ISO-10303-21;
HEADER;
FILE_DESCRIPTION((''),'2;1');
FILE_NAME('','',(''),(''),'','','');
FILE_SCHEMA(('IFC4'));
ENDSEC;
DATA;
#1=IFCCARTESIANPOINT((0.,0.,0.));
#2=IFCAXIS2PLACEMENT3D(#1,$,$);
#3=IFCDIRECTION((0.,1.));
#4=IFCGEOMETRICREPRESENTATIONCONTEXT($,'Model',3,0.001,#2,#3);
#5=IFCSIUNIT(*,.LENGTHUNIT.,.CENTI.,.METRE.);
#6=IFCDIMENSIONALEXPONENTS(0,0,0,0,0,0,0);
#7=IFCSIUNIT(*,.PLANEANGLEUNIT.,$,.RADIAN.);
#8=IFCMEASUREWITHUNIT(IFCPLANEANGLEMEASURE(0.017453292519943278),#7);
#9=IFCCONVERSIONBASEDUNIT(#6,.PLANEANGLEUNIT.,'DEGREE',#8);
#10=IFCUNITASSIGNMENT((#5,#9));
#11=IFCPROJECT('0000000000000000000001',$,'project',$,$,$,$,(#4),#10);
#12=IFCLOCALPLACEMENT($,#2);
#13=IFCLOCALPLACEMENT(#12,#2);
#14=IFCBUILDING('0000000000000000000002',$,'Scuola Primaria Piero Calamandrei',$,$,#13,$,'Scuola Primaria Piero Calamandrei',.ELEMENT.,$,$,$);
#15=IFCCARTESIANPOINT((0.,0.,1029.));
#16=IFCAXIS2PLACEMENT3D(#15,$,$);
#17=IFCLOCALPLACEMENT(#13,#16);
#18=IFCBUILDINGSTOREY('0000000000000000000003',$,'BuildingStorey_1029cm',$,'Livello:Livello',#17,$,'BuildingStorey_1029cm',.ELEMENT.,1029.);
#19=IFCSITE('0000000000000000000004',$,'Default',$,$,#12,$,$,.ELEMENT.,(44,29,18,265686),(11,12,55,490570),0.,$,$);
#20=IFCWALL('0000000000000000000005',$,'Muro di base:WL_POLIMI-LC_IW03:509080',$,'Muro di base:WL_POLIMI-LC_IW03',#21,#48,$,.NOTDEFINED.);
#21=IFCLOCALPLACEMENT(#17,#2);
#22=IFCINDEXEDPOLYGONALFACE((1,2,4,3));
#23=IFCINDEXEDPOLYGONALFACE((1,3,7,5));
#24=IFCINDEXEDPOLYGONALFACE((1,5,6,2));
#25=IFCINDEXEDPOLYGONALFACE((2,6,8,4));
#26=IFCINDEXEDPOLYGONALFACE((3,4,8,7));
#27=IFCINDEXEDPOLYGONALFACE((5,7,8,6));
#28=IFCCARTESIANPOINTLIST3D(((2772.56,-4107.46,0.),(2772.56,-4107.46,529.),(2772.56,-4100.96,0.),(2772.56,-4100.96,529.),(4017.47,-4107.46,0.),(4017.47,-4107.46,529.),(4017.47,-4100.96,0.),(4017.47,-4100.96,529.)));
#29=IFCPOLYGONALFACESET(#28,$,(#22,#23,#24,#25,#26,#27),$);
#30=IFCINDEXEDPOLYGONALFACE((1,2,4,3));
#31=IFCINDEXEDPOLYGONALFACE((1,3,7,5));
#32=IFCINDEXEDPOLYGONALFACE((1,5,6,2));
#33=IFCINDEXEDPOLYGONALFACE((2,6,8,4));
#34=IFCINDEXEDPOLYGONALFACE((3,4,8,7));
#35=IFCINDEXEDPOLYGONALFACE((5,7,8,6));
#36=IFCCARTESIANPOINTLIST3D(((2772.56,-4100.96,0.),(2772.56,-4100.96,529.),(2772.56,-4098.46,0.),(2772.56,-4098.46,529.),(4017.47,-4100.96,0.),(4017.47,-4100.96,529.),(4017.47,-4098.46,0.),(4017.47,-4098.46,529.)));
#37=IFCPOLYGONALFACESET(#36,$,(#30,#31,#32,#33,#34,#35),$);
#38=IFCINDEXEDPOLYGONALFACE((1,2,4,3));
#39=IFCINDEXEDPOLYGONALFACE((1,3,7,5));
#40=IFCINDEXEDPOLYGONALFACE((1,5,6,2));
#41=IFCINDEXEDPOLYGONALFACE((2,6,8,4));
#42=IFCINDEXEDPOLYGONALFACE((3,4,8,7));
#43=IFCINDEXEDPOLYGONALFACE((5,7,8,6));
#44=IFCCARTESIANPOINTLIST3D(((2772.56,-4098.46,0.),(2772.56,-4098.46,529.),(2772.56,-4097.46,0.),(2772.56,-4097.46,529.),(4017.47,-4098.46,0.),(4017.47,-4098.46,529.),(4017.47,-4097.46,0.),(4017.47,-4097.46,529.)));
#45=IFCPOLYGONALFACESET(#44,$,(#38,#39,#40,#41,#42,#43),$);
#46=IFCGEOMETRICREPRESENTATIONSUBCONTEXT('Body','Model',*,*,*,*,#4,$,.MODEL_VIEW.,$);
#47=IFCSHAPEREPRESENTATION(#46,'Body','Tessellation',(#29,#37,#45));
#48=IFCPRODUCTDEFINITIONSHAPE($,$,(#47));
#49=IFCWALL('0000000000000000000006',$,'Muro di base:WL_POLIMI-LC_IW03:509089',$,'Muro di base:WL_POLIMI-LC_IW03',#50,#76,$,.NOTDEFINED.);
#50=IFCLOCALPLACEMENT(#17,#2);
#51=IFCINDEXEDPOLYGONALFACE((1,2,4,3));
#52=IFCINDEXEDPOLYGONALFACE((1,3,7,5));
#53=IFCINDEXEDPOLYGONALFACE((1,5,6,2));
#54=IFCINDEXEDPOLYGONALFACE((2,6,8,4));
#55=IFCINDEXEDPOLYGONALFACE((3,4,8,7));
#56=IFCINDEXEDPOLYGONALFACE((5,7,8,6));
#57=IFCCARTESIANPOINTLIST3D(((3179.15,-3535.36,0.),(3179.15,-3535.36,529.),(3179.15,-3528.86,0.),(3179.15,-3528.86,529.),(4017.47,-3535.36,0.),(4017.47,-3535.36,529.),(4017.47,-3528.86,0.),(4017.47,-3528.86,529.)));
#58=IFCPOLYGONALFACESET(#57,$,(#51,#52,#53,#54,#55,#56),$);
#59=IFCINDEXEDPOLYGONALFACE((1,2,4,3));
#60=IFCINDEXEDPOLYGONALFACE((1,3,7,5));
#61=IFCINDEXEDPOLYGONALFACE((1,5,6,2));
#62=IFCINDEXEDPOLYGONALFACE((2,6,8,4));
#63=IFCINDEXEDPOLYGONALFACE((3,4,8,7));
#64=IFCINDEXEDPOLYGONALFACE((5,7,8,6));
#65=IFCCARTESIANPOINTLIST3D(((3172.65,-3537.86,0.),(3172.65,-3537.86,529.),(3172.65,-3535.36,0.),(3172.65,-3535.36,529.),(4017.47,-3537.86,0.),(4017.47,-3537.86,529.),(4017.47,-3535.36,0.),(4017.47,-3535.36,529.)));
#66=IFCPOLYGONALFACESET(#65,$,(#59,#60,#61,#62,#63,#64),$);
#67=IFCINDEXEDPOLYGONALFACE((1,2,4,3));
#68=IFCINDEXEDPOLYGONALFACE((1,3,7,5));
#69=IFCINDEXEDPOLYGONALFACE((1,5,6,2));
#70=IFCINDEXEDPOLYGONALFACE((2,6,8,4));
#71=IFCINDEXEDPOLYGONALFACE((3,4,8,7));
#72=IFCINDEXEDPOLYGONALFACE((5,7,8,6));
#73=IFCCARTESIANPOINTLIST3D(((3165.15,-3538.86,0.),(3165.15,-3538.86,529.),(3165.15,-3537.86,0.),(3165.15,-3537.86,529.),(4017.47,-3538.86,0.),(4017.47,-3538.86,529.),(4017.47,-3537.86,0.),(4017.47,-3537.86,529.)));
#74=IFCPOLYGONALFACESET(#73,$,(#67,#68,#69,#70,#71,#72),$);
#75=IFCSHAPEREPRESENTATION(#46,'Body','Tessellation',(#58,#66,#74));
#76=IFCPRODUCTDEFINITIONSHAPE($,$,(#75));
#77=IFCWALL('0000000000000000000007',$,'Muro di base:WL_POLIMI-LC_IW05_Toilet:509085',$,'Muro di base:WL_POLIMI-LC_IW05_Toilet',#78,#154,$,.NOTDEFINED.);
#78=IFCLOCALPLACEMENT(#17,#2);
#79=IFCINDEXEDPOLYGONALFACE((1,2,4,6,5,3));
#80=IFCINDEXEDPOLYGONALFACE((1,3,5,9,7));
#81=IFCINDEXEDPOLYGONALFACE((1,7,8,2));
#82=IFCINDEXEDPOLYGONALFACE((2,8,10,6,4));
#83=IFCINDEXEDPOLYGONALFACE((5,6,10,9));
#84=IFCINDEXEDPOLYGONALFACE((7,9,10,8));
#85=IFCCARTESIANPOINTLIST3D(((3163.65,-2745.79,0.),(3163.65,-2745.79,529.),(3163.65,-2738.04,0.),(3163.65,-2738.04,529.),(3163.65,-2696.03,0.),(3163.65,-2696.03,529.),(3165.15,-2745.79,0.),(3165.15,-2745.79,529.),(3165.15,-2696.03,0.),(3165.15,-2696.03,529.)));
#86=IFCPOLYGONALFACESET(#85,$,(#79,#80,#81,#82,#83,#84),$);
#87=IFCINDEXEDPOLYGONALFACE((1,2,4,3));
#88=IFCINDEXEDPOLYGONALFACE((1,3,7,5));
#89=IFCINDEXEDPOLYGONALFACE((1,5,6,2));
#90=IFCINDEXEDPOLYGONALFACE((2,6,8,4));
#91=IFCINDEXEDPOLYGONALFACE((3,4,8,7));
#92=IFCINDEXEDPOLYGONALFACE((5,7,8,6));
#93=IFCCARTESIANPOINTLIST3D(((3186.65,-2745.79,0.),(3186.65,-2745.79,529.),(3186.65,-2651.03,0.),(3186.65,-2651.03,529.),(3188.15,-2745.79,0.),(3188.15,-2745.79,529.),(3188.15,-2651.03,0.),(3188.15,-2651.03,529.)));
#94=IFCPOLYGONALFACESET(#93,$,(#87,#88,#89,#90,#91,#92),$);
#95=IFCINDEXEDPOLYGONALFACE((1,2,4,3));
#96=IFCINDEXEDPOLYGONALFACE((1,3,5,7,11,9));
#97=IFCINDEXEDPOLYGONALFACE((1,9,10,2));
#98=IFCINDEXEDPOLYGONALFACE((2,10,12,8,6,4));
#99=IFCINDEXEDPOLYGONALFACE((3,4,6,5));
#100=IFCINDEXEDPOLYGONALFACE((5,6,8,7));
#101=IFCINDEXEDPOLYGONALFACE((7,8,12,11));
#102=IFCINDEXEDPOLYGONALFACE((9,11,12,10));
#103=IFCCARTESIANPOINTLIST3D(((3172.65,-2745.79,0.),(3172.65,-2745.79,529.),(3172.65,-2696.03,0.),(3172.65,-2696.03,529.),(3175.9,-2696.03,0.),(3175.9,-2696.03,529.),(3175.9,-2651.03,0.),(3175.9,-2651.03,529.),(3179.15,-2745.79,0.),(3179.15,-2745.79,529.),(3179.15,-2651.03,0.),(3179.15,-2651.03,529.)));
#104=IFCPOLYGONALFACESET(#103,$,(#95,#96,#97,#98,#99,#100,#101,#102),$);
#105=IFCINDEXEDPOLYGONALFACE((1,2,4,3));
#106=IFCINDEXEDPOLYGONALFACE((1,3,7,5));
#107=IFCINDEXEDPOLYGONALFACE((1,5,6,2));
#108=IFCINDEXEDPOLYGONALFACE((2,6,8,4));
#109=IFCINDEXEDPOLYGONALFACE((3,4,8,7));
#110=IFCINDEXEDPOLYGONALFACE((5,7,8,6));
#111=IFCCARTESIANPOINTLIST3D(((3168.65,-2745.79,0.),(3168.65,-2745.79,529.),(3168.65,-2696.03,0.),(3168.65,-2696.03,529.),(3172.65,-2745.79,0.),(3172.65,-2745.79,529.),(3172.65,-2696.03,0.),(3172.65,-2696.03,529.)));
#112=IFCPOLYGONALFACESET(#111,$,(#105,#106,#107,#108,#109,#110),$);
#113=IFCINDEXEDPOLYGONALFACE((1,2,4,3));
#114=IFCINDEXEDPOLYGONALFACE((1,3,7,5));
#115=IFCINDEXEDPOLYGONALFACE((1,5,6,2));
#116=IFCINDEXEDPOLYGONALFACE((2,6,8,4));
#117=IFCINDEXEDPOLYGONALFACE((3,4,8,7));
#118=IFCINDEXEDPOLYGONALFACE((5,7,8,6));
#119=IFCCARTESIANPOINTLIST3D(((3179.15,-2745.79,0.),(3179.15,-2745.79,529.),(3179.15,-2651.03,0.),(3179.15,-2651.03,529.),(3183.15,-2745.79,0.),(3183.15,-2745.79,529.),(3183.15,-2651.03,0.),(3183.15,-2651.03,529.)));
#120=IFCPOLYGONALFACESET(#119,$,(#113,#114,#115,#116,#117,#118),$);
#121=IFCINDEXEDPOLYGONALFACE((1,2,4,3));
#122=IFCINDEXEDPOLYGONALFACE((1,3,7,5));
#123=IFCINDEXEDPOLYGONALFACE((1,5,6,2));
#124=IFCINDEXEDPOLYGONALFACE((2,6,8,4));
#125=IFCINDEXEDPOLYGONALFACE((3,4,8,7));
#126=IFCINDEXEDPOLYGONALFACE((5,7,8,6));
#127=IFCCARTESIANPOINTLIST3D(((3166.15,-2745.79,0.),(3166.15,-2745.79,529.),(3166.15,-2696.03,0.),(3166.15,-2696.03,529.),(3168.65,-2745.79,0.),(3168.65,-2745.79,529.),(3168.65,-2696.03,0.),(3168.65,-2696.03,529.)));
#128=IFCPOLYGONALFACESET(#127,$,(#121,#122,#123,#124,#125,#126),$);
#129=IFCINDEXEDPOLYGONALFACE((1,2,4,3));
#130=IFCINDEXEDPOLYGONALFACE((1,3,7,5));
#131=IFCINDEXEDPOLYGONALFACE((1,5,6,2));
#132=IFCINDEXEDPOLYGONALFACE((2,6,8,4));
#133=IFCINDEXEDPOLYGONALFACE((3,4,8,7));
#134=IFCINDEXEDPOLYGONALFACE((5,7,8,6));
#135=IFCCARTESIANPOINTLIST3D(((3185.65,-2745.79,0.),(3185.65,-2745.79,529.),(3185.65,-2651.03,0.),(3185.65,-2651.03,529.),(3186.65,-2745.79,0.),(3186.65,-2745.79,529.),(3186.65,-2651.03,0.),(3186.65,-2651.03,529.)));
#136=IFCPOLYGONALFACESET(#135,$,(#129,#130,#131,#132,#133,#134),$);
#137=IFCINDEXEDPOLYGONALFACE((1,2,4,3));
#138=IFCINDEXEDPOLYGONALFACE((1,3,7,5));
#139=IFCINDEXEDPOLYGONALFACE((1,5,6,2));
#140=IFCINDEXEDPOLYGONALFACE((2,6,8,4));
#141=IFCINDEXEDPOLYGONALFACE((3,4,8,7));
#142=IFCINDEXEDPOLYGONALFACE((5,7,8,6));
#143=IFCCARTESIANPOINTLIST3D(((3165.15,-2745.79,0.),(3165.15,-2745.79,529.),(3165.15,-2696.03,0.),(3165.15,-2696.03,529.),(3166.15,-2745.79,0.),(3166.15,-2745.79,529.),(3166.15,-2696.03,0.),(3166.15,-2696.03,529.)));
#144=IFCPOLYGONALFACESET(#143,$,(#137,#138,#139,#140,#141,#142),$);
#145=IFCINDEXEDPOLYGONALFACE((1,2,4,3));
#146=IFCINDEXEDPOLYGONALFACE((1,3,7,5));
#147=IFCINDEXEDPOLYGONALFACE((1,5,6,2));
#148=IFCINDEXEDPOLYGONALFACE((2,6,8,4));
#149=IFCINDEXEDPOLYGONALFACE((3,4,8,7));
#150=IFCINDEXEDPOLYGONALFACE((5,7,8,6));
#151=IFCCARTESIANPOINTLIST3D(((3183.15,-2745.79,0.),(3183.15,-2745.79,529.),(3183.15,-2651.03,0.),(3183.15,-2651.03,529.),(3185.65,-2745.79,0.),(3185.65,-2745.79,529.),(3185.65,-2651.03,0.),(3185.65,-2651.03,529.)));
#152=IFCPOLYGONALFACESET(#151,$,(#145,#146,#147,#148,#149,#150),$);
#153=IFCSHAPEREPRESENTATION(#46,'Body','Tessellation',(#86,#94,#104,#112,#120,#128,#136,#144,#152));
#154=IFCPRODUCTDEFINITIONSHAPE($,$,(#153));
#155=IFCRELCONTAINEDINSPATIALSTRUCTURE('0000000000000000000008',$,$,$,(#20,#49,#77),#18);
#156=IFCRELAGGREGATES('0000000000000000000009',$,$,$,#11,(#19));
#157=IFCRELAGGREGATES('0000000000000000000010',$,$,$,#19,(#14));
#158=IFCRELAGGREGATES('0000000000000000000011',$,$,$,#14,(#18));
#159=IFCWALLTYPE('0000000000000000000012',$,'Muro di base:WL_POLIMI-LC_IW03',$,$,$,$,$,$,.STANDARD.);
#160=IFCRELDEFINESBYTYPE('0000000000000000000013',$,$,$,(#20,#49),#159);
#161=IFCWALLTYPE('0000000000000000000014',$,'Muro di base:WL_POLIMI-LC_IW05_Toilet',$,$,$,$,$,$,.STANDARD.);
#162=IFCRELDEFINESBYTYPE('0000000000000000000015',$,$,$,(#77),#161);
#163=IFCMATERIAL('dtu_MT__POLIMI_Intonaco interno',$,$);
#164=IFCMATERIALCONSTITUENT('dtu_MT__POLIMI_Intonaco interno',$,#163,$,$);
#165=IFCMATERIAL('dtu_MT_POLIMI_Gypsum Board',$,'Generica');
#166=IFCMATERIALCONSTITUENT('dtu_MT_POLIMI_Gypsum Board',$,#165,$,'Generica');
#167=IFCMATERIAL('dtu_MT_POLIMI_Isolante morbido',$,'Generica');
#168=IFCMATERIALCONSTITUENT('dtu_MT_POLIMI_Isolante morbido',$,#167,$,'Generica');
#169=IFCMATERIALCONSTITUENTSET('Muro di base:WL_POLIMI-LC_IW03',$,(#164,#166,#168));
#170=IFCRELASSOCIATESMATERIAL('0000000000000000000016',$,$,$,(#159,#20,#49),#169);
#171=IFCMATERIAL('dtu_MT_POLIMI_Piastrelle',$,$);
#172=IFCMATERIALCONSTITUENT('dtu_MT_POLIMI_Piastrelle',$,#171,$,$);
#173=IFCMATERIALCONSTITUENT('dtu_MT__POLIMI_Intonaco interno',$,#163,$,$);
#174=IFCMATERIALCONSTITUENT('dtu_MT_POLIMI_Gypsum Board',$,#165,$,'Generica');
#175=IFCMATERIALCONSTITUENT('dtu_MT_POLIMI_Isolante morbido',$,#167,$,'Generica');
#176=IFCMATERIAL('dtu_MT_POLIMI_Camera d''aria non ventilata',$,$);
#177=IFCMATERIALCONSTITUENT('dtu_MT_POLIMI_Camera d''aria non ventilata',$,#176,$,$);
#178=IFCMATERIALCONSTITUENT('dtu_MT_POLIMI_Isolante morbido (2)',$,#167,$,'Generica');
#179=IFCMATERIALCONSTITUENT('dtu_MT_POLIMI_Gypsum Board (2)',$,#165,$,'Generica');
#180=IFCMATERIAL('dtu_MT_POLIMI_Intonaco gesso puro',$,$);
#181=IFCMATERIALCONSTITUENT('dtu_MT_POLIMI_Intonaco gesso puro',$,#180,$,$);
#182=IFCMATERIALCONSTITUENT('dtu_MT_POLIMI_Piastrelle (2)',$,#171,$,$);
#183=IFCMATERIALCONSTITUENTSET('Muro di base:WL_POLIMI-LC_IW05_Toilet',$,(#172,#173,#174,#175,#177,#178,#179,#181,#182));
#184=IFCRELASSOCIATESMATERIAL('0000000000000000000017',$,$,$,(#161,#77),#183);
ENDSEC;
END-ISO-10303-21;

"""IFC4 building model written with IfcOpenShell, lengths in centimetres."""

from ifc_helpers import new_model, entity, si_unit, converted_unit, direction, frame, origin, place, context, subcontext, project, spatial, indexed_curve, outline, extrude, material, constituent, constituent_set, type_object, element, save


model = new_model("IFC4")

# Units and contexts
model_context = context("Model", 3, precision=0.001, world=origin(), true_north=direction((0.0, 1.0)))
body_context = subcontext(model_context, "Body", "Model", "MODEL_VIEW")
ifc_project = project(units=[si_unit("LENGTHUNIT", "METRE", prefix="CENTI"), converted_unit("PLANEANGLEUNIT", "DEGREE", entity("IfcPlaneAngleMeasure", 0.017453292519943278), si_unit("PLANEANGLEUNIT", "RADIAN"), dimensions=[0, 0, 0, 0, 0, 0, 0])], contexts=[model_context])

# Site, building, storey
site_placement = place(None, origin())
site = spatial("IfcSite", under=ifc_project, at=site_placement, Name="Default", CompositionType="ELEMENT", RefLatitude=(44, 29, 18, 265686), RefLongitude=(11, 12, 55, 490570), RefElevation=0.0)
building_placement = place(site_placement, origin())
building = spatial("IfcBuilding", under=site, at=building_placement, Name="Scuola Primaria Piero Calamandrei", LongName="Scuola Primaria Piero Calamandrei", CompositionType="ELEMENT")
storey_placement = place(building_placement, frame((0.0, 0.0, 1029.0)))
storey = spatial("IfcBuildingStorey", under=building, at=storey_placement, Name="BuildingStorey_1029cm", ObjectType="Livello:Livello", LongName="BuildingStorey_1029cm", CompositionType="ELEMENT", Elevation=1029.0)

# Shared definitions
ifc_material_1 = material(Name="dtu_MT_POLIMI_Isolante morbido", Category="Generica")
ifc_material_2 = material(Name="dtu_MT_POLIMI_Gypsum Board", Category="Generica")
ifc_material_3 = material(Name="dtu_MT__POLIMI_Intonaco interno")

# Shared definitions
ifc_material_4 = material(Name="dtu_MT_POLIMI_Camera d'aria non ventilata")
ifc_material_5 = material(Name="dtu_MT_POLIMI_Intonaco gesso puro")

# Walls
ifc_constituent_1 = constituent(ifc_material_3, Name="dtu_MT__POLIMI_Intonaco interno")
ifc_constituent_2 = constituent(ifc_material_2, Name="dtu_MT_POLIMI_Gypsum Board", Category="Generica")
ifc_constituent_3 = constituent(ifc_material_1, Name="dtu_MT_POLIMI_Isolante morbido", Category="Generica")
ifc_constituent_set_1 = constituent_set(constituents=[ifc_constituent_1, ifc_constituent_2, ifc_constituent_3], Name="Muro di base:WL_POLIMI-LC_IW03")
wall_type_1 = type_object("IfcWallType", Name="Muro di base:WL_POLIMI-LC_IW03", PredefinedType="STANDARD", material=ifc_constituent_set_1)
wall_1_placement = place(storey_placement, frame((2772.56, -4102.46, 0.0)))
element("IfcWall", 1, at=wall_1_placement, inside=storey, type_object=wall_type_1, material=ifc_constituent_set_1, Name="Muro di base:WL_POLIMI-LC_IW03:509080", ObjectType="Muro di base:WL_POLIMI-LC_IW03", PredefinedType="NOTDEFINED", context=body_context, shape_type="SweptSolid", body=[
    extrude(outline(indexed_curve([(-3.25, -622.46), (3.25, -622.46), (3.25, 622.46), (-3.25, 622.46), (-3.25, -622.46)], self_intersect=False)), frame((622.46, -1.75, 0.0), z_axis=(0.0, 0.0, 1.0), x_axis=(0.0, 1.0, 0.0)), (0.0, 0.0, 1.0), 529.0),
    extrude(outline(indexed_curve([(-622.46, -1.25), (622.46, -1.25), (622.46, 1.25), (-622.46, 1.25), (-622.46, -1.25)], self_intersect=False)), frame((622.46, 2.75, 0.0)), (0.0, 0.0, 1.0), 529.0),
    extrude(outline(indexed_curve([(-0.5, -622.46), (0.5, -622.46), (0.5, 622.46), (-0.5, 622.46), (-0.5, -622.46)], self_intersect=False)), frame((622.46, 4.5, 0.0), z_axis=(0.0, 0.0, 1.0), x_axis=(0.0, -1.0, 0.0)), (0.0, 0.0, 1.0), 529.0),
])
wall_2_placement = place(storey_placement, frame((4017.47, -3533.86, 0.0), z_axis=(0.0, 0.0, 1.0), x_axis=(-1.0, 0.0, 0.0)))
element("IfcWall", 2, at=wall_2_placement, inside=storey, type_object=wall_type_1, material=ifc_constituent_set_1, Name="Muro di base:WL_POLIMI-LC_IW03:509089", ObjectType="Muro di base:WL_POLIMI-LC_IW03", PredefinedType="NOTDEFINED", context=body_context, shape_type="SweptSolid", body=[
    extrude(outline(indexed_curve([(-3.25, -419.16), (3.25, -419.16), (3.25, 419.16), (-3.25, 419.16), (-3.25, -419.16)], self_intersect=False)), frame((419.16, -1.75, 0.0), z_axis=(0.0, 0.0, 1.0), x_axis=(0.0, 1.0, 0.0)), (0.0, 0.0, 1.0), 529.0),
    extrude(outline(indexed_curve([(-422.41, -1.25), (422.41, -1.25), (422.41, 1.25), (-422.41, 1.25), (-422.41, -1.25)], self_intersect=False)), frame((422.41, 2.75, 0.0)), (0.0, 0.0, 1.0), 529.0),
    extrude(outline(indexed_curve([(-0.5, -426.16), (0.5, -426.16), (0.5, 426.16), (-0.5, 426.16), (-0.5, -426.16)], self_intersect=False)), frame((426.16, 4.5, 0.0), z_axis=(0.0, 0.0, 1.0), x_axis=(0.0, -1.0, 0.0)), (0.0, 0.0, 1.0), 529.0),
])

# Shared definitions
ifc_material_6 = material(Name="dtu_MT_POLIMI_Piastrelle")

# Wall
ifc_constituent_4 = constituent(ifc_material_6, Name="dtu_MT_POLIMI_Piastrelle")
ifc_constituent_5 = constituent(ifc_material_3, Name="dtu_MT__POLIMI_Intonaco interno")
ifc_constituent_6 = constituent(ifc_material_2, Name="dtu_MT_POLIMI_Gypsum Board", Category="Generica")
ifc_constituent_7 = constituent(ifc_material_1, Name="dtu_MT_POLIMI_Isolante morbido", Category="Generica")
ifc_constituent_8 = constituent(ifc_material_4, Name="dtu_MT_POLIMI_Camera d'aria non ventilata")
ifc_constituent_9 = constituent(ifc_material_1, Name="dtu_MT_POLIMI_Isolante morbido (2)", Category="Generica")
ifc_constituent_10 = constituent(ifc_material_2, Name="dtu_MT_POLIMI_Gypsum Board (2)", Category="Generica")
ifc_constituent_11 = constituent(ifc_material_5, Name="dtu_MT_POLIMI_Intonaco gesso puro")
ifc_constituent_12 = constituent(ifc_material_6, Name="dtu_MT_POLIMI_Piastrelle (2)")
ifc_constituent_set_2 = constituent_set(constituents=[ifc_constituent_4, ifc_constituent_5, ifc_constituent_6, ifc_constituent_7, ifc_constituent_8, ifc_constituent_9, ifc_constituent_10, ifc_constituent_11, ifc_constituent_12], Name="Muro di base:WL_POLIMI-LC_IW05_Toilet")
wall_type_2 = type_object("IfcWallType", Name="Muro di base:WL_POLIMI-LC_IW05_Toilet", PredefinedType="STANDARD", material=ifc_constituent_set_2)
wall_3_placement = place(storey_placement, frame((3175.9, -2745.79, 0.0), z_axis=(0.0, 0.0, 1.0), x_axis=(0.0, 1.0, 0.0)))
element("IfcWall", 3, at=wall_3_placement, inside=storey, type_object=wall_type_2, material=ifc_constituent_set_2, Name="Muro di base:WL_POLIMI-LC_IW05_Toilet:509085", ObjectType="Muro di base:WL_POLIMI-LC_IW05_Toilet", PredefinedType="NOTDEFINED", context=body_context, shape_type="SweptSolid", body=[
    extrude(outline(indexed_curve([(13.7, -0.6), (21.45, -0.6), (21.45, 0.9), (-28.3, 0.9), (-28.3, -0.6), (13.7, -0.6)], self_intersect=False)), frame((21.45, 11.65, 0.0), z_axis=(0.0, 0.0, 1.0), x_axis=(-1.0, 0.0, 0.0)), (0.0, 0.0, 1.0), 529.0),
    extrude(outline(indexed_curve([(-0.75, -47.38), (0.75, -47.38), (0.75, 47.38), (-0.75, 47.38), (-0.75, -47.38)], self_intersect=False)), frame((47.38, -11.5, 0.0), z_axis=(0.0, 0.0, 1.0), x_axis=(0.0, 1.0, 0.0)), (0.0, 0.0, 1.0), 529.0),
    extrude(outline(indexed_curve([(0.0, -1.59), (3.25, -1.59), (3.25, 48.17), (-3.25, 48.17), (-3.25, -46.59), (0.0, -46.59), (0.0, -1.59)], self_intersect=False)), frame((48.17, 0.0, 0.0), z_axis=(0.0, 0.0, 1.0), x_axis=(0.0, 1.0, 0.0)), (0.0, 0.0, 1.0), 529.0),
    extrude(outline(indexed_curve([(-24.88, -2.0), (24.88, -2.0), (24.88, 2.0), (-24.88, 2.0), (-24.88, -2.0)], self_intersect=False)), frame((24.88, 5.25, 0.0)), (0.0, 0.0, 1.0), 529.0),
    extrude(outline(indexed_curve([(-47.38, -2.0), (47.38, -2.0), (47.38, 2.0), (-47.38, 2.0), (-47.38, -2.0)], self_intersect=False)), frame((47.38, -5.25, 0.0)), (0.0, 0.0, 1.0), 529.0),
    extrude(outline(indexed_curve([(-24.88, -1.25), (24.88, -1.25), (24.88, 1.25), (-24.88, 1.25), (-24.88, -1.25)], self_intersect=False)), frame((24.88, 8.5, 0.0)), (0.0, 0.0, 1.0), 529.0),
    extrude(outline(indexed_curve([(-47.38, -0.5), (47.38, -0.5), (47.38, 0.5), (-47.38, 0.5), (-47.38, -0.5)], self_intersect=False)), frame((47.38, -10.25, 0.0)), (0.0, 0.0, 1.0), 529.0),
    extrude(outline(indexed_curve([(-24.88, -0.5), (24.88, -0.5), (24.88, 0.5), (-24.88, 0.5), (-24.88, -0.5)], self_intersect=False)), frame((24.88, 10.25, 0.0)), (0.0, 0.0, 1.0), 529.0),
    extrude(outline(indexed_curve([(-47.38, -1.25), (47.38, -1.25), (47.38, 1.25), (-47.38, 1.25), (-47.38, -1.25)], self_intersect=False)), frame((47.38, -8.5, 0.0)), (0.0, 0.0, 1.0), 529.0),
])

save(model, "model.ifc")
